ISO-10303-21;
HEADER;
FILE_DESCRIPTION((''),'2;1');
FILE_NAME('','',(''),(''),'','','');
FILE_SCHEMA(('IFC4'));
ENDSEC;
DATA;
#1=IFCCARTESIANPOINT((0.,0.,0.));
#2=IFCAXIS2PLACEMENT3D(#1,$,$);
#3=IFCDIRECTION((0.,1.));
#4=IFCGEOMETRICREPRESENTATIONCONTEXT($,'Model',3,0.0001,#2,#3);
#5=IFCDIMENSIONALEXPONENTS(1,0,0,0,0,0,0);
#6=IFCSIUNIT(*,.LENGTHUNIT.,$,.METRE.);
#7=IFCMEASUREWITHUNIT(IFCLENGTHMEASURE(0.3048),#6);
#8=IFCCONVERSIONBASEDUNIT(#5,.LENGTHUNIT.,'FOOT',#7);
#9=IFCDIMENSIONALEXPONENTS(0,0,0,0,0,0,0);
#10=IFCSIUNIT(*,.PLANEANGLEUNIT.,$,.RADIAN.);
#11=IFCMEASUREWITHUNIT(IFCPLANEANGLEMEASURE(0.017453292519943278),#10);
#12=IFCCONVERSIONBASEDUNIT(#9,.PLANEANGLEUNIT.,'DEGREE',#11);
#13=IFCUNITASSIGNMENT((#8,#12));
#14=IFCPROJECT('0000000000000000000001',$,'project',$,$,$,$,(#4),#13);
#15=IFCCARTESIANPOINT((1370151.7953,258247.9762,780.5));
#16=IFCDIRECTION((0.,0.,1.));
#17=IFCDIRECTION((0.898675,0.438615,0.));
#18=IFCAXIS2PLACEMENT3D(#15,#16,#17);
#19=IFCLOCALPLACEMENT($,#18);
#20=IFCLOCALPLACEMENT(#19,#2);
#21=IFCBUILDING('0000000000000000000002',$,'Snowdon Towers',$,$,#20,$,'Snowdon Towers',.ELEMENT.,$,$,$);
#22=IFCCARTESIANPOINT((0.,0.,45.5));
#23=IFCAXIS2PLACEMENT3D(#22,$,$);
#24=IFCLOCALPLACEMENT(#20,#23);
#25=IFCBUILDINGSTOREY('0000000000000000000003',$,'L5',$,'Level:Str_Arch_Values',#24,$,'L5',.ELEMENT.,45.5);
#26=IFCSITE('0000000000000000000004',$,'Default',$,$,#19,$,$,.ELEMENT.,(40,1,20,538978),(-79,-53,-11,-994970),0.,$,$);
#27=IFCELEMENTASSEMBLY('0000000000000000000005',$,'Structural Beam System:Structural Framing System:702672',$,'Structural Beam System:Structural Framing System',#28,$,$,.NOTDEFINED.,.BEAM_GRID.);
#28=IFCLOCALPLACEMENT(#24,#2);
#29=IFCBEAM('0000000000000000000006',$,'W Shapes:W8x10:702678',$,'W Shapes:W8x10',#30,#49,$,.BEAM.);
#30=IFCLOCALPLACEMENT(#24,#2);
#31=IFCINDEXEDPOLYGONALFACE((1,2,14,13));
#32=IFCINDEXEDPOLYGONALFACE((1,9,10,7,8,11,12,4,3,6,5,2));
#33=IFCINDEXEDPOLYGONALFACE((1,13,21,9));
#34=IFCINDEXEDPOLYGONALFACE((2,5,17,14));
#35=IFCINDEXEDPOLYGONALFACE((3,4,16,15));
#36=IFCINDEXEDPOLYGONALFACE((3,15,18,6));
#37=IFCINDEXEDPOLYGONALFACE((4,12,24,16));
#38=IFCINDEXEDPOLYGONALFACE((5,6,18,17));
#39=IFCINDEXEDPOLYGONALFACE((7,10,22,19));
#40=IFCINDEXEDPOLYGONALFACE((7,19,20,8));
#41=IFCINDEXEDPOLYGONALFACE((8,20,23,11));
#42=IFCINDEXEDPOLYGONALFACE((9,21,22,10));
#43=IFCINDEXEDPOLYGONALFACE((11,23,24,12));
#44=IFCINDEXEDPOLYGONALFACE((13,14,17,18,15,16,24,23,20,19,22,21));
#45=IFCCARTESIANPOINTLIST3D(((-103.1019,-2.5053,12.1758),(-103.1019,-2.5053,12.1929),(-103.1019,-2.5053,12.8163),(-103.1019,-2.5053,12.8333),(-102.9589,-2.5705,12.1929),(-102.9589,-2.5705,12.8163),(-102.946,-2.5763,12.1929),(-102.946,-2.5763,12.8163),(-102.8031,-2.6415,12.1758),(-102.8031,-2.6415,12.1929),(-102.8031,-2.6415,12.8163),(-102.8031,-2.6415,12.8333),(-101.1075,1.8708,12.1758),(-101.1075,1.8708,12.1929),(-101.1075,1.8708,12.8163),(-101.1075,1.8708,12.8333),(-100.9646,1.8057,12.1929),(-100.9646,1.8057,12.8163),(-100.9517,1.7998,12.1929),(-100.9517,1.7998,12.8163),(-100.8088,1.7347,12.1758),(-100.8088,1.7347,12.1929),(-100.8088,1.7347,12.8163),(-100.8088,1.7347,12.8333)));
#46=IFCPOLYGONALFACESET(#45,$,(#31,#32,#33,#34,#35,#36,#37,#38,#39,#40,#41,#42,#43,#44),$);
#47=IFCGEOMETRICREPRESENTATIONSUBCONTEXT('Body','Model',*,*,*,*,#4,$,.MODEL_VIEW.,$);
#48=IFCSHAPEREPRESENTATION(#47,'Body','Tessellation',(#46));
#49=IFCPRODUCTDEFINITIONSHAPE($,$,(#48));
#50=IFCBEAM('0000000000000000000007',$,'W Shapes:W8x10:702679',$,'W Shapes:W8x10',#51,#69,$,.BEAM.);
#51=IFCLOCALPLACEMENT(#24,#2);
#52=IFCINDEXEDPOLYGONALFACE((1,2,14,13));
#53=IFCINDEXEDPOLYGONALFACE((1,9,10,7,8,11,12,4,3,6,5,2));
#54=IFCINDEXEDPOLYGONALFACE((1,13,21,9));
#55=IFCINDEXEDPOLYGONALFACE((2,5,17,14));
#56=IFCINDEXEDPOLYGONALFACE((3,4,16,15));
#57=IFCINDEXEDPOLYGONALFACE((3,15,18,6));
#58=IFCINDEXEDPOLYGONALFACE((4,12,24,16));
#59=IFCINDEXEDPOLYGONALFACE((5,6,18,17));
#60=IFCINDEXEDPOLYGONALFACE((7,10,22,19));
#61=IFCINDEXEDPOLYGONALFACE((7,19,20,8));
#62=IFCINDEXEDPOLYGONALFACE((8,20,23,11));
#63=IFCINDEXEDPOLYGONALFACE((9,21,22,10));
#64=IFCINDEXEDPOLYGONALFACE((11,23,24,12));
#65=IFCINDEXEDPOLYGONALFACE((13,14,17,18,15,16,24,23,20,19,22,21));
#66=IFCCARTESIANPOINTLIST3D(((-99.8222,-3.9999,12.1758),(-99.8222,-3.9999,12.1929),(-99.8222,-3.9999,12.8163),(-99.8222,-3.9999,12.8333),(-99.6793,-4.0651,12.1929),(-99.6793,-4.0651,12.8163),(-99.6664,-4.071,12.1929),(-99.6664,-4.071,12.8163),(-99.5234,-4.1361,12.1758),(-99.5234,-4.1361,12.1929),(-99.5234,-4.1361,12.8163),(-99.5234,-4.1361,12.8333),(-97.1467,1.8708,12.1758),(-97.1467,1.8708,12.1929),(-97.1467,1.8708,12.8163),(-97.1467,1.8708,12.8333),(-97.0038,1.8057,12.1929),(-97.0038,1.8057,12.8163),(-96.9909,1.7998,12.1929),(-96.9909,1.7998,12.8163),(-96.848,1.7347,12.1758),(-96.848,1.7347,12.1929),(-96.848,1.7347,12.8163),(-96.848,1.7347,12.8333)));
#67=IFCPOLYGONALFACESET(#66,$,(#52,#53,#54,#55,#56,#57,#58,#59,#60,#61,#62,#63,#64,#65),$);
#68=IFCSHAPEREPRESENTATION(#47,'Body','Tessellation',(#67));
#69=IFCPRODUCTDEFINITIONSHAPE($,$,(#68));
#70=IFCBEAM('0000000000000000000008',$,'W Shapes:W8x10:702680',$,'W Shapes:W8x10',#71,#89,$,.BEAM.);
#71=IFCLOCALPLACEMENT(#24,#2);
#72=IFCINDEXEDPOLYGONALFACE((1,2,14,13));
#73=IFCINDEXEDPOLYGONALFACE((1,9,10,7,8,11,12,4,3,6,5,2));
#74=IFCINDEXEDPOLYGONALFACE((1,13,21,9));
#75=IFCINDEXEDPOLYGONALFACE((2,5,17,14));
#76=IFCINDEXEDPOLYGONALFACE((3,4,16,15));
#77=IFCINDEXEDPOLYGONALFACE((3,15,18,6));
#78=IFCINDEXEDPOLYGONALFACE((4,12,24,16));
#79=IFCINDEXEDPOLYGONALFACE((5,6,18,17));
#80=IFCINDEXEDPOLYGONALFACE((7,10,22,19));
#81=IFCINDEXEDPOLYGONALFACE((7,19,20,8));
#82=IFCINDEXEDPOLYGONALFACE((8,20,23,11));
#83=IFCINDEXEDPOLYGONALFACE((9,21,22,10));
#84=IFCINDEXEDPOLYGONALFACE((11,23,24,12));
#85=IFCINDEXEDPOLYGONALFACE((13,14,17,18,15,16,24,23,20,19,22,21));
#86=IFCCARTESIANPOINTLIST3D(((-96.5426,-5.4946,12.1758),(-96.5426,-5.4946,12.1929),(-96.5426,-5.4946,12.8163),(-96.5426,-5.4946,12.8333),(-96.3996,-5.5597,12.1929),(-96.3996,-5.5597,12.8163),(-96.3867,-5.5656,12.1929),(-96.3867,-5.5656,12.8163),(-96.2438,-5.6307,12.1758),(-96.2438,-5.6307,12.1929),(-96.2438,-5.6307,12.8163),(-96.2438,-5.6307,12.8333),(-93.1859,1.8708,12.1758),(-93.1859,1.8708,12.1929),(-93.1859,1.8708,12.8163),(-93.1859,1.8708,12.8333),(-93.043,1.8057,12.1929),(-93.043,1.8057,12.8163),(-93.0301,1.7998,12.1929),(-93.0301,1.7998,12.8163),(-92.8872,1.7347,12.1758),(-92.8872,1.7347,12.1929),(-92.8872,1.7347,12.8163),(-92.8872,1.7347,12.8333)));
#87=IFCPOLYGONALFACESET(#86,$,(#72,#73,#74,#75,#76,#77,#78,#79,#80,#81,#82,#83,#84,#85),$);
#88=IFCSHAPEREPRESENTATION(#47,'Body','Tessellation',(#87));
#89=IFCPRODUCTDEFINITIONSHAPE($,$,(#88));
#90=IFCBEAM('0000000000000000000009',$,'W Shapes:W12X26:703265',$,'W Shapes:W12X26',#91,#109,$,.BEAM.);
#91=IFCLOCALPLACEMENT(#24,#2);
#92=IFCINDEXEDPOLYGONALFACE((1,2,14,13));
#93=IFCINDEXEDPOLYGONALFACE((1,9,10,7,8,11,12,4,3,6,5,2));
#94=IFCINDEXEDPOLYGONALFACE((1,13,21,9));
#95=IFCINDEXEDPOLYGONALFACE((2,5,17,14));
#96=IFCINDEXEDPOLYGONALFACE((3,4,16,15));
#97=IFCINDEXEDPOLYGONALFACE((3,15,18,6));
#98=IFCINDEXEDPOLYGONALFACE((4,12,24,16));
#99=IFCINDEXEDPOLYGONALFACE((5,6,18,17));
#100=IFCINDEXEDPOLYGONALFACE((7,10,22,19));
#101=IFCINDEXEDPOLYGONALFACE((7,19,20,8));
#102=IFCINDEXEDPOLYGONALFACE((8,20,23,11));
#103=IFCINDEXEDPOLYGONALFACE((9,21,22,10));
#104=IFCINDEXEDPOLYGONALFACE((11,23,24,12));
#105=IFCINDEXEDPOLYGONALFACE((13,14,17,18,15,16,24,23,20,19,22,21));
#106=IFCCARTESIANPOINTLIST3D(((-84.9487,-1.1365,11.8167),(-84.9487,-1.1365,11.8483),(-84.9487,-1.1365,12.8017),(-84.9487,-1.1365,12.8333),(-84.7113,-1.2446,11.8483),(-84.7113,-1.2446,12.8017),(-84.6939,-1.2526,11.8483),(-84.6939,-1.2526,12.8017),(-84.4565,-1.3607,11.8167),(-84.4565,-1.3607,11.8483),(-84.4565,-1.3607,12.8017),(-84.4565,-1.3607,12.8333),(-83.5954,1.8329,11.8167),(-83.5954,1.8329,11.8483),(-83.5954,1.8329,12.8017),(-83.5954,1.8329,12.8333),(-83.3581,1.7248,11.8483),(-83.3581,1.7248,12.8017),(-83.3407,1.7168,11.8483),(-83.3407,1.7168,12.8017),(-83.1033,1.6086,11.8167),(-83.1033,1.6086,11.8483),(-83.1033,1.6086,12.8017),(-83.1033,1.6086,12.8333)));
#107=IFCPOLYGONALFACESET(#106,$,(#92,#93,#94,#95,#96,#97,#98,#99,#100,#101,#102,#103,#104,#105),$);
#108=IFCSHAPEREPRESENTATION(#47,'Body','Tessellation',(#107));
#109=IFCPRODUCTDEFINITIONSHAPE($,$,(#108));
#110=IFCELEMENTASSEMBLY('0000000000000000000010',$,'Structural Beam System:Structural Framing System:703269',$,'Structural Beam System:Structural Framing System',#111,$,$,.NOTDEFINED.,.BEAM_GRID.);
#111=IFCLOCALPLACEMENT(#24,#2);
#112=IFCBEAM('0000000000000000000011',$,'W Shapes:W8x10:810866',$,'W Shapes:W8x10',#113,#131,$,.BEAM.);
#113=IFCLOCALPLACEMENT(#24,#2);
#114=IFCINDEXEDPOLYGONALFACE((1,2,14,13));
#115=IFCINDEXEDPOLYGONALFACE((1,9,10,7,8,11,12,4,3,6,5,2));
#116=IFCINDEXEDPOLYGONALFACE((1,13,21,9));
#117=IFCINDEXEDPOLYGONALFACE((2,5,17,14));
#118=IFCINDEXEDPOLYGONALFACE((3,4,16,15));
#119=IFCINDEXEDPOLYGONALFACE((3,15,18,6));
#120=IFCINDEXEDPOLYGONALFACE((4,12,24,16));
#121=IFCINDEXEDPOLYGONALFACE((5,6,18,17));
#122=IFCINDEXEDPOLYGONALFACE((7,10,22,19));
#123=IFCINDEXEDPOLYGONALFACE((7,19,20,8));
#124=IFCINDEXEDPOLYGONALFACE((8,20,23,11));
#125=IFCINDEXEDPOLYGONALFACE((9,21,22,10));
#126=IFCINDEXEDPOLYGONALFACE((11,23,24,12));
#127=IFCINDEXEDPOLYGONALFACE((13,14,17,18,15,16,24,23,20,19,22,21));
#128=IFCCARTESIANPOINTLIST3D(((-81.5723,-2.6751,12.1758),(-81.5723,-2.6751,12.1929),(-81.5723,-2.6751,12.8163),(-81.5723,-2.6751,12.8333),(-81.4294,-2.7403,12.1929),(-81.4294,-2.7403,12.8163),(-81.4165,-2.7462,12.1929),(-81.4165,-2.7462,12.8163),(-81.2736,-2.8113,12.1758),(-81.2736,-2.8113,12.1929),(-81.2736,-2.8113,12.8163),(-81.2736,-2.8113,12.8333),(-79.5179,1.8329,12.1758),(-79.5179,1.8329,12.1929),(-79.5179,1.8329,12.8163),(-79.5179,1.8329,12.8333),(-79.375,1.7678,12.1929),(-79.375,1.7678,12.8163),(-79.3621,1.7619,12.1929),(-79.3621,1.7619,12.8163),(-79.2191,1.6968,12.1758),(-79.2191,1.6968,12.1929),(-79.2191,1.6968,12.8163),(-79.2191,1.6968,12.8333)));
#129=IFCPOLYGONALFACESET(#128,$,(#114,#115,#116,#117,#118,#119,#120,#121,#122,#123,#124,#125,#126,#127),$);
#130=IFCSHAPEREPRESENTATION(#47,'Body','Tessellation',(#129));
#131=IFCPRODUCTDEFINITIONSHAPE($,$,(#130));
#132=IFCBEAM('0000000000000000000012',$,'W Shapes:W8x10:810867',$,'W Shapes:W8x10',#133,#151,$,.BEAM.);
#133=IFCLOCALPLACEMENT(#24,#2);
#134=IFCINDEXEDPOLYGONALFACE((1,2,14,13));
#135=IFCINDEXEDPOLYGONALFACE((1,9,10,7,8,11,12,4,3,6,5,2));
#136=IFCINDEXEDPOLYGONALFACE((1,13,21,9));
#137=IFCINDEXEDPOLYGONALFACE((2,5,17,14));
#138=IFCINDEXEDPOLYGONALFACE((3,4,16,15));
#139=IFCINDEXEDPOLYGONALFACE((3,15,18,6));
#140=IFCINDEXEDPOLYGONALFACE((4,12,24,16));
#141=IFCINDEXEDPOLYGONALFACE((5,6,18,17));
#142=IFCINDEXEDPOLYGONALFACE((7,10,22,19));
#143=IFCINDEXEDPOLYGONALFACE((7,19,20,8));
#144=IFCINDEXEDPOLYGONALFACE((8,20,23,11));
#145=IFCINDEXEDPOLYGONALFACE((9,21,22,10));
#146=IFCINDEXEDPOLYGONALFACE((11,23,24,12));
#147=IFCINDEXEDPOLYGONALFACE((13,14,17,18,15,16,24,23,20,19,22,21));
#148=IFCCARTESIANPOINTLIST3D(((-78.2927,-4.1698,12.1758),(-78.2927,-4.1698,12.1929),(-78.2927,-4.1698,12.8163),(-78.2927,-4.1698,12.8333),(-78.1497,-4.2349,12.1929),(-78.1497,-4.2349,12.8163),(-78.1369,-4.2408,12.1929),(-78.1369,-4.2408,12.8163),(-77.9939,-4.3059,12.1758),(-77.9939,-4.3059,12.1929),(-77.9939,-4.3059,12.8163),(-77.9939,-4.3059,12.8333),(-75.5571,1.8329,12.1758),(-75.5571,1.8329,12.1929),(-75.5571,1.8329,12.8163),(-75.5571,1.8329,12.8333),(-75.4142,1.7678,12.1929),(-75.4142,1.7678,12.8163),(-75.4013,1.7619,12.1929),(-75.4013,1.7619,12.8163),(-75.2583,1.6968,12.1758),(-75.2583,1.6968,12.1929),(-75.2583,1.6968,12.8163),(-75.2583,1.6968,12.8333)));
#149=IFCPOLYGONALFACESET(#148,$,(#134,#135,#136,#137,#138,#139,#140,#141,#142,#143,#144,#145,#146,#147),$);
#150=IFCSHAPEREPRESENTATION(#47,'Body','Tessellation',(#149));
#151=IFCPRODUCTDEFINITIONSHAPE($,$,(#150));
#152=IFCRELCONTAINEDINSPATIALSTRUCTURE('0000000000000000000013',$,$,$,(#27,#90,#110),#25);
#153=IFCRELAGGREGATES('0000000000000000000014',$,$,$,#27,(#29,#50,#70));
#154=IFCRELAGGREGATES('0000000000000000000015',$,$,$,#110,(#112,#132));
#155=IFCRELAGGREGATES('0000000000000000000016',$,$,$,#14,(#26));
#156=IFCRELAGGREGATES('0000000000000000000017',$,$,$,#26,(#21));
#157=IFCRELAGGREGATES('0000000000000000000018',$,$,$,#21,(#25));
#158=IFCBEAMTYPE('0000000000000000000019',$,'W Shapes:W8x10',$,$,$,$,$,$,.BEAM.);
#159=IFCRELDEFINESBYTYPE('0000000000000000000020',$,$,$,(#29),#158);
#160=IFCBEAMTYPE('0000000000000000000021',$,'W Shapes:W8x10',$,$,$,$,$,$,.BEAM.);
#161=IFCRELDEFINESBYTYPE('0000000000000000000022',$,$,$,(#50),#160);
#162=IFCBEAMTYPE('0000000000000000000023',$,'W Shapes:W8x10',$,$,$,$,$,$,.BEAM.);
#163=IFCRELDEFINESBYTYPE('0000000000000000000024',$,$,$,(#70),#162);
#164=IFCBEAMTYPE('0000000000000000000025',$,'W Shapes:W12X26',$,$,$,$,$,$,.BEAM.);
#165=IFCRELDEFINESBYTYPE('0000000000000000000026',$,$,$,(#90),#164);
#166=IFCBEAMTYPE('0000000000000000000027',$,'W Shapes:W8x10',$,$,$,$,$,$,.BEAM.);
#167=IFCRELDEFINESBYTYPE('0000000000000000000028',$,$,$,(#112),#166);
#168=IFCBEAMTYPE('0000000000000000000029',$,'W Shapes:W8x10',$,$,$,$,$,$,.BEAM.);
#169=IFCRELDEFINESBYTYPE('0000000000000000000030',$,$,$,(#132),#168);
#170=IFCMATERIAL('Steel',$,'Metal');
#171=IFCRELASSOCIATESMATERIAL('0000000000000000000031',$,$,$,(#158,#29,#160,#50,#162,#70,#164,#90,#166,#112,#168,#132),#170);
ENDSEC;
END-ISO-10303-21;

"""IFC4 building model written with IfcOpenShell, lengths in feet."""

from ifc_helpers import new_model, entity, si_unit, converted_unit, direction, frame, origin, place, context, subcontext, project, spatial, indexed_curve, outline, extrude, source, transform, mapped, material, type_object, type_shapes, element, aggregate, save


model = new_model("IFC4")

# Units and contexts
model_context = context("Model", 3, precision=0.0001, world=origin(), true_north=direction((0.0, 1.0)))
body_context = subcontext(model_context, "Body", "Model", "MODEL_VIEW")
ifc_project = project(units=[converted_unit("LENGTHUNIT", "FOOT", entity("IfcLengthMeasure", 0.3048), si_unit("LENGTHUNIT", "METRE"), dimensions=[1, 0, 0, 0, 0, 0, 0]), converted_unit("PLANEANGLEUNIT", "DEGREE", entity("IfcPlaneAngleMeasure", 0.017453292519943278), si_unit("PLANEANGLEUNIT", "RADIAN"), dimensions=[0, 0, 0, 0, 0, 0, 0])], contexts=[model_context])

# Site, building, storey
site_placement = place(None, frame((1370151.7953, 258247.9762, 780.5), z_axis=(0.0, 0.0, 1.0), x_axis=(0.898675, 0.438615, 0.0)))
site = spatial("IfcSite", under=ifc_project, at=site_placement, Name="Default", CompositionType="ELEMENT", RefLatitude=(40, 1, 20, 538978), RefLongitude=(-79, -53, -11, -994970), RefElevation=0.0)
building_placement = place(site_placement, origin())
building = spatial("IfcBuilding", under=site, at=building_placement, Name="Snowdon Towers", LongName="Snowdon Towers", CompositionType="ELEMENT")
storey_placement = place(building_placement, frame((0.0, 0.0, 45.5)))
storey = spatial("IfcBuildingStorey", under=building, at=storey_placement, Name="L5", ObjectType="Level:Str_Arch_Values", LongName="L5", CompositionType="ELEMENT", Elevation=45.5)

# Shared definitions
ifc_material = material(Name="Steel", Category="Metal")

# Element assembly, beams
assembly_1_placement = place(storey_placement, origin())
assembly_1 = element("IfcElementAssembly", 1, at=assembly_1_placement, inside=storey, Name="Structural Beam System:Structural Framing System:702672", ObjectType="Structural Beam System:Structural Framing System", AssemblyPlace="NOTDEFINED", PredefinedType="BEAM_GRID")
beam_type_1 = type_object("IfcBeamType", Name="W Shapes:W8x10", PredefinedType="BEAM", material=ifc_material)
shared_shape_1 = source(origin(), body_context, "Body", "SweptSolid", [
    extrude(outline(indexed_curve([(-0.1642, -0.3117), (-0.1642, -0.3288), (0.1642, -0.3288), (0.1642, -0.3117), (0.0071, -0.3117), (0.0071, 0.3117), (0.1642, 0.3117), (0.1642, 0.3287), (-0.1642, 0.3287), (-0.1642, 0.3117), (-0.0071, 0.3117), (-0.0071, -0.3117), (-0.1642, -0.3117)], self_intersect=False)), frame((-2.6525, 0.0, 0.0), z_axis=(-1.0, 0.0, 0.0), x_axis=(0.0, -1.0, 0.0)), (0.0, 0.0, -1.0), 4.8092),
])
type_shapes(beam_type_1, [shared_shape_1])
beam_1_placement = place(assembly_1_placement, frame((-101.8525, -0.1597, 12.5046), z_axis=(0.0, 0.0, 1.0), x_axis=(0.414693, 0.909961, 0.0)))
beam_1 = element("IfcBeam", 2, at=beam_1_placement, type_object=beam_type_1, material=ifc_material, Name="W Shapes:W8x10:702678", ObjectType="W Shapes:W8x10", PredefinedType="BEAM", context=body_context, shape_type="MappedRepresentation", body=[
    mapped(shared_shape_1, transform((0.0, 0.0, 0.0), scale=1.0)),
])
beam_type_2 = type_object("IfcBeamType", Name="W Shapes:W8x10", PredefinedType="BEAM", material=ifc_material)
shared_shape_2 = source(origin(), body_context, "Body", "SweptSolid", [
    extrude(outline(indexed_curve([(-0.1642, -0.3117), (-0.1642, -0.3288), (0.1642, -0.3288), (0.1642, -0.3117), (0.0071, -0.3117), (0.0071, 0.3117), (0.1642, 0.3117), (0.1642, 0.3287), (-0.1642, 0.3287), (-0.1642, 0.3117), (-0.0071, 0.3117), (-0.0071, -0.3117), (-0.1642, -0.3117)], self_intersect=False)), frame((-3.4738, 0.0, 0.0), z_axis=(-1.0, 0.0, 0.0), x_axis=(0.0, -1.0, 0.0)), (0.0, 0.0, -1.0), 6.4517),
])
type_shapes(beam_type_2, [shared_shape_2])
beam_2_placement = place(assembly_1_placement, frame((-98.2323, -0.907, 12.5046), z_axis=(0.0, 0.0, 1.0), x_axis=(0.414693, 0.909961, 0.0)))
beam_2 = element("IfcBeam", 3, at=beam_2_placement, type_object=beam_type_2, material=ifc_material, Name="W Shapes:W8x10:702679", ObjectType="W Shapes:W8x10", PredefinedType="BEAM", context=body_context, shape_type="MappedRepresentation", body=[
    mapped(shared_shape_2, transform((0.0, 0.0, 0.0), scale=1.0)),
])
beam_type_3 = type_object("IfcBeamType", Name="W Shapes:W8x10", PredefinedType="BEAM", material=ifc_material)
shared_shape_3 = source(origin(), body_context, "Body", "SweptSolid", [
    extrude(outline(indexed_curve([(-0.1642, -0.3117), (-0.1642, -0.3288), (0.1642, -0.3288), (0.1642, -0.3117), (0.0071, -0.3117), (0.0071, 0.3117), (0.1642, 0.3117), (0.1642, 0.3287), (-0.1642, 0.3287), (-0.1642, 0.3117), (-0.0071, 0.3117), (-0.0071, -0.3117), (-0.1642, -0.3117)], self_intersect=False)), frame((-4.295, 0.0, 0.0), z_axis=(-1.0, 0.0, 0.0), x_axis=(0.0, -1.0, 0.0)), (0.0, 0.0, -1.0), 8.0942),
])
type_shapes(beam_type_3, [shared_shape_3])
beam_3_placement = place(assembly_1_placement, frame((-94.6121, -1.6544, 12.5046), z_axis=(0.0, 0.0, 1.0), x_axis=(0.414693, 0.909961, 0.0)))
beam_3 = element("IfcBeam", 4, at=beam_3_placement, type_object=beam_type_3, material=ifc_material, Name="W Shapes:W8x10:702680", ObjectType="W Shapes:W8x10", PredefinedType="BEAM", context=body_context, shape_type="MappedRepresentation", body=[
    mapped(shared_shape_3, transform((0.0, 0.0, 0.0), scale=1.0)),
])
aggregate(assembly_1, [beam_1, beam_2, beam_3])

# Beam
beam_type_4 = type_object("IfcBeamType", Name="W Shapes:W12X26", PredefinedType="BEAM", material=ifc_material)
shared_shape_4 = source(origin(), body_context, "Body", "SweptSolid", [
    extrude(outline(indexed_curve([(-0.2704, -0.4767), (-0.2704, -0.5083), (0.2704, -0.5083), (0.2704, -0.4767), (0.0096, -0.4767), (0.0096, 0.4767), (0.2704, 0.4767), (0.2704, 0.5083), (-0.2704, 0.5083), (-0.2704, 0.4767), (-0.0096, 0.4767), (-0.0096, -0.4767), (-0.2704, -0.4767)], self_intersect=False)), frame((-1.9037, 0.0, 0.0), z_axis=(-1.0, 0.0, 0.0), x_axis=(0.0, -1.0, 0.0)), (0.0, 0.0, -1.0), 3.2632),
])
type_shapes(beam_type_4, [shared_shape_4])
beam_4_placement = place(storey_placement, frame((-83.9131, 0.4837, 12.325), z_axis=(0.0, 0.0, 1.0), x_axis=(0.414693, 0.909961, 0.0)))
element("IfcBeam", 5, at=beam_4_placement, inside=storey, type_object=beam_type_4, material=ifc_material, Name="W Shapes:W12X26:703265", ObjectType="W Shapes:W12X26", PredefinedType="BEAM", context=body_context, shape_type="MappedRepresentation", body=[
    mapped(shared_shape_4, transform((0.0, 0.0, 0.0), scale=1.0)),
])

# Element assembly, beams
assembly_2_placement = place(storey_placement, origin())
assembly_2 = element("IfcElementAssembly", 6, at=assembly_2_placement, inside=storey, Name="Structural Beam System:Structural Framing System:703269", ObjectType="Structural Beam System:Structural Framing System", AssemblyPlace="NOTDEFINED", PredefinedType="BEAM_GRID")
beam_type_5 = type_object("IfcBeamType", Name="W Shapes:W8x10", PredefinedType="BEAM", material=ifc_material)
shared_shape_5 = source(origin(), body_context, "Body", "SweptSolid", [
    extrude(outline(indexed_curve([(-0.1642, -0.3117), (-0.1642, -0.3288), (0.1642, -0.3288), (0.1642, -0.3117), (0.0071, -0.3117), (0.0071, 0.3117), (0.1642, 0.3117), (0.1642, 0.3287), (-0.1642, 0.3287), (-0.1642, 0.3117), (-0.0071, 0.3117), (-0.0071, -0.3117), (-0.1642, -0.3117)], self_intersect=False)), frame((-2.725, 0.0, 0.0), z_axis=(-1.0, 0.0, 0.0), x_axis=(0.0, -1.0, 0.0)), (0.0, 0.0, -1.0), 4.9541),
])
type_shapes(beam_type_5, [shared_shape_5])
beam_5_placement = place(assembly_2_placement, frame((-80.2929, -0.2636, 12.5046), z_axis=(0.0, 0.0, 1.0), x_axis=(0.414693, 0.909961, 0.0)))
beam_5 = element("IfcBeam", 7, at=beam_5_placement, type_object=beam_type_5, material=ifc_material, Name="W Shapes:W8x10:810866", ObjectType="W Shapes:W8x10", PredefinedType="BEAM", context=body_context, shape_type="MappedRepresentation", body=[
    mapped(shared_shape_5, transform((0.0, 0.0, 0.0), scale=1.0)),
])
beam_type_6 = type_object("IfcBeamType", Name="W Shapes:W8x10", PredefinedType="BEAM", material=ifc_material)
shared_shape_6 = source(origin(), body_context, "Body", "SweptSolid", [
    extrude(outline(indexed_curve([(-0.1642, -0.3117), (-0.1642, -0.3288), (0.1642, -0.3288), (0.1642, -0.3117), (0.0071, -0.3117), (0.0071, 0.3117), (0.1642, 0.3117), (0.1642, 0.3287), (-0.1642, 0.3287), (-0.1642, 0.3117), (-0.0071, 0.3117), (-0.0071, -0.3117), (-0.1642, -0.3117)], self_intersect=False)), frame((-3.5462, 0.0, 0.0), z_axis=(-1.0, 0.0, 0.0), x_axis=(0.0, -1.0, 0.0)), (0.0, 0.0, -1.0), 6.5966),
])
type_shapes(beam_type_6, [shared_shape_6])
beam_6_placement = place(assembly_2_placement, frame((-76.6727, -1.0109, 12.5046), z_axis=(0.0, 0.0, 1.0), x_axis=(0.414693, 0.909961, 0.0)))
beam_6 = element("IfcBeam", 8, at=beam_6_placement, type_object=beam_type_6, material=ifc_material, Name="W Shapes:W8x10:810867", ObjectType="W Shapes:W8x10", PredefinedType="BEAM", context=body_context, shape_type="MappedRepresentation", body=[
    mapped(shared_shape_6, transform((0.0, 0.0, 0.0), scale=1.0)),
])
aggregate(assembly_2, [beam_5, beam_6])

save(model, "model.ifc")
